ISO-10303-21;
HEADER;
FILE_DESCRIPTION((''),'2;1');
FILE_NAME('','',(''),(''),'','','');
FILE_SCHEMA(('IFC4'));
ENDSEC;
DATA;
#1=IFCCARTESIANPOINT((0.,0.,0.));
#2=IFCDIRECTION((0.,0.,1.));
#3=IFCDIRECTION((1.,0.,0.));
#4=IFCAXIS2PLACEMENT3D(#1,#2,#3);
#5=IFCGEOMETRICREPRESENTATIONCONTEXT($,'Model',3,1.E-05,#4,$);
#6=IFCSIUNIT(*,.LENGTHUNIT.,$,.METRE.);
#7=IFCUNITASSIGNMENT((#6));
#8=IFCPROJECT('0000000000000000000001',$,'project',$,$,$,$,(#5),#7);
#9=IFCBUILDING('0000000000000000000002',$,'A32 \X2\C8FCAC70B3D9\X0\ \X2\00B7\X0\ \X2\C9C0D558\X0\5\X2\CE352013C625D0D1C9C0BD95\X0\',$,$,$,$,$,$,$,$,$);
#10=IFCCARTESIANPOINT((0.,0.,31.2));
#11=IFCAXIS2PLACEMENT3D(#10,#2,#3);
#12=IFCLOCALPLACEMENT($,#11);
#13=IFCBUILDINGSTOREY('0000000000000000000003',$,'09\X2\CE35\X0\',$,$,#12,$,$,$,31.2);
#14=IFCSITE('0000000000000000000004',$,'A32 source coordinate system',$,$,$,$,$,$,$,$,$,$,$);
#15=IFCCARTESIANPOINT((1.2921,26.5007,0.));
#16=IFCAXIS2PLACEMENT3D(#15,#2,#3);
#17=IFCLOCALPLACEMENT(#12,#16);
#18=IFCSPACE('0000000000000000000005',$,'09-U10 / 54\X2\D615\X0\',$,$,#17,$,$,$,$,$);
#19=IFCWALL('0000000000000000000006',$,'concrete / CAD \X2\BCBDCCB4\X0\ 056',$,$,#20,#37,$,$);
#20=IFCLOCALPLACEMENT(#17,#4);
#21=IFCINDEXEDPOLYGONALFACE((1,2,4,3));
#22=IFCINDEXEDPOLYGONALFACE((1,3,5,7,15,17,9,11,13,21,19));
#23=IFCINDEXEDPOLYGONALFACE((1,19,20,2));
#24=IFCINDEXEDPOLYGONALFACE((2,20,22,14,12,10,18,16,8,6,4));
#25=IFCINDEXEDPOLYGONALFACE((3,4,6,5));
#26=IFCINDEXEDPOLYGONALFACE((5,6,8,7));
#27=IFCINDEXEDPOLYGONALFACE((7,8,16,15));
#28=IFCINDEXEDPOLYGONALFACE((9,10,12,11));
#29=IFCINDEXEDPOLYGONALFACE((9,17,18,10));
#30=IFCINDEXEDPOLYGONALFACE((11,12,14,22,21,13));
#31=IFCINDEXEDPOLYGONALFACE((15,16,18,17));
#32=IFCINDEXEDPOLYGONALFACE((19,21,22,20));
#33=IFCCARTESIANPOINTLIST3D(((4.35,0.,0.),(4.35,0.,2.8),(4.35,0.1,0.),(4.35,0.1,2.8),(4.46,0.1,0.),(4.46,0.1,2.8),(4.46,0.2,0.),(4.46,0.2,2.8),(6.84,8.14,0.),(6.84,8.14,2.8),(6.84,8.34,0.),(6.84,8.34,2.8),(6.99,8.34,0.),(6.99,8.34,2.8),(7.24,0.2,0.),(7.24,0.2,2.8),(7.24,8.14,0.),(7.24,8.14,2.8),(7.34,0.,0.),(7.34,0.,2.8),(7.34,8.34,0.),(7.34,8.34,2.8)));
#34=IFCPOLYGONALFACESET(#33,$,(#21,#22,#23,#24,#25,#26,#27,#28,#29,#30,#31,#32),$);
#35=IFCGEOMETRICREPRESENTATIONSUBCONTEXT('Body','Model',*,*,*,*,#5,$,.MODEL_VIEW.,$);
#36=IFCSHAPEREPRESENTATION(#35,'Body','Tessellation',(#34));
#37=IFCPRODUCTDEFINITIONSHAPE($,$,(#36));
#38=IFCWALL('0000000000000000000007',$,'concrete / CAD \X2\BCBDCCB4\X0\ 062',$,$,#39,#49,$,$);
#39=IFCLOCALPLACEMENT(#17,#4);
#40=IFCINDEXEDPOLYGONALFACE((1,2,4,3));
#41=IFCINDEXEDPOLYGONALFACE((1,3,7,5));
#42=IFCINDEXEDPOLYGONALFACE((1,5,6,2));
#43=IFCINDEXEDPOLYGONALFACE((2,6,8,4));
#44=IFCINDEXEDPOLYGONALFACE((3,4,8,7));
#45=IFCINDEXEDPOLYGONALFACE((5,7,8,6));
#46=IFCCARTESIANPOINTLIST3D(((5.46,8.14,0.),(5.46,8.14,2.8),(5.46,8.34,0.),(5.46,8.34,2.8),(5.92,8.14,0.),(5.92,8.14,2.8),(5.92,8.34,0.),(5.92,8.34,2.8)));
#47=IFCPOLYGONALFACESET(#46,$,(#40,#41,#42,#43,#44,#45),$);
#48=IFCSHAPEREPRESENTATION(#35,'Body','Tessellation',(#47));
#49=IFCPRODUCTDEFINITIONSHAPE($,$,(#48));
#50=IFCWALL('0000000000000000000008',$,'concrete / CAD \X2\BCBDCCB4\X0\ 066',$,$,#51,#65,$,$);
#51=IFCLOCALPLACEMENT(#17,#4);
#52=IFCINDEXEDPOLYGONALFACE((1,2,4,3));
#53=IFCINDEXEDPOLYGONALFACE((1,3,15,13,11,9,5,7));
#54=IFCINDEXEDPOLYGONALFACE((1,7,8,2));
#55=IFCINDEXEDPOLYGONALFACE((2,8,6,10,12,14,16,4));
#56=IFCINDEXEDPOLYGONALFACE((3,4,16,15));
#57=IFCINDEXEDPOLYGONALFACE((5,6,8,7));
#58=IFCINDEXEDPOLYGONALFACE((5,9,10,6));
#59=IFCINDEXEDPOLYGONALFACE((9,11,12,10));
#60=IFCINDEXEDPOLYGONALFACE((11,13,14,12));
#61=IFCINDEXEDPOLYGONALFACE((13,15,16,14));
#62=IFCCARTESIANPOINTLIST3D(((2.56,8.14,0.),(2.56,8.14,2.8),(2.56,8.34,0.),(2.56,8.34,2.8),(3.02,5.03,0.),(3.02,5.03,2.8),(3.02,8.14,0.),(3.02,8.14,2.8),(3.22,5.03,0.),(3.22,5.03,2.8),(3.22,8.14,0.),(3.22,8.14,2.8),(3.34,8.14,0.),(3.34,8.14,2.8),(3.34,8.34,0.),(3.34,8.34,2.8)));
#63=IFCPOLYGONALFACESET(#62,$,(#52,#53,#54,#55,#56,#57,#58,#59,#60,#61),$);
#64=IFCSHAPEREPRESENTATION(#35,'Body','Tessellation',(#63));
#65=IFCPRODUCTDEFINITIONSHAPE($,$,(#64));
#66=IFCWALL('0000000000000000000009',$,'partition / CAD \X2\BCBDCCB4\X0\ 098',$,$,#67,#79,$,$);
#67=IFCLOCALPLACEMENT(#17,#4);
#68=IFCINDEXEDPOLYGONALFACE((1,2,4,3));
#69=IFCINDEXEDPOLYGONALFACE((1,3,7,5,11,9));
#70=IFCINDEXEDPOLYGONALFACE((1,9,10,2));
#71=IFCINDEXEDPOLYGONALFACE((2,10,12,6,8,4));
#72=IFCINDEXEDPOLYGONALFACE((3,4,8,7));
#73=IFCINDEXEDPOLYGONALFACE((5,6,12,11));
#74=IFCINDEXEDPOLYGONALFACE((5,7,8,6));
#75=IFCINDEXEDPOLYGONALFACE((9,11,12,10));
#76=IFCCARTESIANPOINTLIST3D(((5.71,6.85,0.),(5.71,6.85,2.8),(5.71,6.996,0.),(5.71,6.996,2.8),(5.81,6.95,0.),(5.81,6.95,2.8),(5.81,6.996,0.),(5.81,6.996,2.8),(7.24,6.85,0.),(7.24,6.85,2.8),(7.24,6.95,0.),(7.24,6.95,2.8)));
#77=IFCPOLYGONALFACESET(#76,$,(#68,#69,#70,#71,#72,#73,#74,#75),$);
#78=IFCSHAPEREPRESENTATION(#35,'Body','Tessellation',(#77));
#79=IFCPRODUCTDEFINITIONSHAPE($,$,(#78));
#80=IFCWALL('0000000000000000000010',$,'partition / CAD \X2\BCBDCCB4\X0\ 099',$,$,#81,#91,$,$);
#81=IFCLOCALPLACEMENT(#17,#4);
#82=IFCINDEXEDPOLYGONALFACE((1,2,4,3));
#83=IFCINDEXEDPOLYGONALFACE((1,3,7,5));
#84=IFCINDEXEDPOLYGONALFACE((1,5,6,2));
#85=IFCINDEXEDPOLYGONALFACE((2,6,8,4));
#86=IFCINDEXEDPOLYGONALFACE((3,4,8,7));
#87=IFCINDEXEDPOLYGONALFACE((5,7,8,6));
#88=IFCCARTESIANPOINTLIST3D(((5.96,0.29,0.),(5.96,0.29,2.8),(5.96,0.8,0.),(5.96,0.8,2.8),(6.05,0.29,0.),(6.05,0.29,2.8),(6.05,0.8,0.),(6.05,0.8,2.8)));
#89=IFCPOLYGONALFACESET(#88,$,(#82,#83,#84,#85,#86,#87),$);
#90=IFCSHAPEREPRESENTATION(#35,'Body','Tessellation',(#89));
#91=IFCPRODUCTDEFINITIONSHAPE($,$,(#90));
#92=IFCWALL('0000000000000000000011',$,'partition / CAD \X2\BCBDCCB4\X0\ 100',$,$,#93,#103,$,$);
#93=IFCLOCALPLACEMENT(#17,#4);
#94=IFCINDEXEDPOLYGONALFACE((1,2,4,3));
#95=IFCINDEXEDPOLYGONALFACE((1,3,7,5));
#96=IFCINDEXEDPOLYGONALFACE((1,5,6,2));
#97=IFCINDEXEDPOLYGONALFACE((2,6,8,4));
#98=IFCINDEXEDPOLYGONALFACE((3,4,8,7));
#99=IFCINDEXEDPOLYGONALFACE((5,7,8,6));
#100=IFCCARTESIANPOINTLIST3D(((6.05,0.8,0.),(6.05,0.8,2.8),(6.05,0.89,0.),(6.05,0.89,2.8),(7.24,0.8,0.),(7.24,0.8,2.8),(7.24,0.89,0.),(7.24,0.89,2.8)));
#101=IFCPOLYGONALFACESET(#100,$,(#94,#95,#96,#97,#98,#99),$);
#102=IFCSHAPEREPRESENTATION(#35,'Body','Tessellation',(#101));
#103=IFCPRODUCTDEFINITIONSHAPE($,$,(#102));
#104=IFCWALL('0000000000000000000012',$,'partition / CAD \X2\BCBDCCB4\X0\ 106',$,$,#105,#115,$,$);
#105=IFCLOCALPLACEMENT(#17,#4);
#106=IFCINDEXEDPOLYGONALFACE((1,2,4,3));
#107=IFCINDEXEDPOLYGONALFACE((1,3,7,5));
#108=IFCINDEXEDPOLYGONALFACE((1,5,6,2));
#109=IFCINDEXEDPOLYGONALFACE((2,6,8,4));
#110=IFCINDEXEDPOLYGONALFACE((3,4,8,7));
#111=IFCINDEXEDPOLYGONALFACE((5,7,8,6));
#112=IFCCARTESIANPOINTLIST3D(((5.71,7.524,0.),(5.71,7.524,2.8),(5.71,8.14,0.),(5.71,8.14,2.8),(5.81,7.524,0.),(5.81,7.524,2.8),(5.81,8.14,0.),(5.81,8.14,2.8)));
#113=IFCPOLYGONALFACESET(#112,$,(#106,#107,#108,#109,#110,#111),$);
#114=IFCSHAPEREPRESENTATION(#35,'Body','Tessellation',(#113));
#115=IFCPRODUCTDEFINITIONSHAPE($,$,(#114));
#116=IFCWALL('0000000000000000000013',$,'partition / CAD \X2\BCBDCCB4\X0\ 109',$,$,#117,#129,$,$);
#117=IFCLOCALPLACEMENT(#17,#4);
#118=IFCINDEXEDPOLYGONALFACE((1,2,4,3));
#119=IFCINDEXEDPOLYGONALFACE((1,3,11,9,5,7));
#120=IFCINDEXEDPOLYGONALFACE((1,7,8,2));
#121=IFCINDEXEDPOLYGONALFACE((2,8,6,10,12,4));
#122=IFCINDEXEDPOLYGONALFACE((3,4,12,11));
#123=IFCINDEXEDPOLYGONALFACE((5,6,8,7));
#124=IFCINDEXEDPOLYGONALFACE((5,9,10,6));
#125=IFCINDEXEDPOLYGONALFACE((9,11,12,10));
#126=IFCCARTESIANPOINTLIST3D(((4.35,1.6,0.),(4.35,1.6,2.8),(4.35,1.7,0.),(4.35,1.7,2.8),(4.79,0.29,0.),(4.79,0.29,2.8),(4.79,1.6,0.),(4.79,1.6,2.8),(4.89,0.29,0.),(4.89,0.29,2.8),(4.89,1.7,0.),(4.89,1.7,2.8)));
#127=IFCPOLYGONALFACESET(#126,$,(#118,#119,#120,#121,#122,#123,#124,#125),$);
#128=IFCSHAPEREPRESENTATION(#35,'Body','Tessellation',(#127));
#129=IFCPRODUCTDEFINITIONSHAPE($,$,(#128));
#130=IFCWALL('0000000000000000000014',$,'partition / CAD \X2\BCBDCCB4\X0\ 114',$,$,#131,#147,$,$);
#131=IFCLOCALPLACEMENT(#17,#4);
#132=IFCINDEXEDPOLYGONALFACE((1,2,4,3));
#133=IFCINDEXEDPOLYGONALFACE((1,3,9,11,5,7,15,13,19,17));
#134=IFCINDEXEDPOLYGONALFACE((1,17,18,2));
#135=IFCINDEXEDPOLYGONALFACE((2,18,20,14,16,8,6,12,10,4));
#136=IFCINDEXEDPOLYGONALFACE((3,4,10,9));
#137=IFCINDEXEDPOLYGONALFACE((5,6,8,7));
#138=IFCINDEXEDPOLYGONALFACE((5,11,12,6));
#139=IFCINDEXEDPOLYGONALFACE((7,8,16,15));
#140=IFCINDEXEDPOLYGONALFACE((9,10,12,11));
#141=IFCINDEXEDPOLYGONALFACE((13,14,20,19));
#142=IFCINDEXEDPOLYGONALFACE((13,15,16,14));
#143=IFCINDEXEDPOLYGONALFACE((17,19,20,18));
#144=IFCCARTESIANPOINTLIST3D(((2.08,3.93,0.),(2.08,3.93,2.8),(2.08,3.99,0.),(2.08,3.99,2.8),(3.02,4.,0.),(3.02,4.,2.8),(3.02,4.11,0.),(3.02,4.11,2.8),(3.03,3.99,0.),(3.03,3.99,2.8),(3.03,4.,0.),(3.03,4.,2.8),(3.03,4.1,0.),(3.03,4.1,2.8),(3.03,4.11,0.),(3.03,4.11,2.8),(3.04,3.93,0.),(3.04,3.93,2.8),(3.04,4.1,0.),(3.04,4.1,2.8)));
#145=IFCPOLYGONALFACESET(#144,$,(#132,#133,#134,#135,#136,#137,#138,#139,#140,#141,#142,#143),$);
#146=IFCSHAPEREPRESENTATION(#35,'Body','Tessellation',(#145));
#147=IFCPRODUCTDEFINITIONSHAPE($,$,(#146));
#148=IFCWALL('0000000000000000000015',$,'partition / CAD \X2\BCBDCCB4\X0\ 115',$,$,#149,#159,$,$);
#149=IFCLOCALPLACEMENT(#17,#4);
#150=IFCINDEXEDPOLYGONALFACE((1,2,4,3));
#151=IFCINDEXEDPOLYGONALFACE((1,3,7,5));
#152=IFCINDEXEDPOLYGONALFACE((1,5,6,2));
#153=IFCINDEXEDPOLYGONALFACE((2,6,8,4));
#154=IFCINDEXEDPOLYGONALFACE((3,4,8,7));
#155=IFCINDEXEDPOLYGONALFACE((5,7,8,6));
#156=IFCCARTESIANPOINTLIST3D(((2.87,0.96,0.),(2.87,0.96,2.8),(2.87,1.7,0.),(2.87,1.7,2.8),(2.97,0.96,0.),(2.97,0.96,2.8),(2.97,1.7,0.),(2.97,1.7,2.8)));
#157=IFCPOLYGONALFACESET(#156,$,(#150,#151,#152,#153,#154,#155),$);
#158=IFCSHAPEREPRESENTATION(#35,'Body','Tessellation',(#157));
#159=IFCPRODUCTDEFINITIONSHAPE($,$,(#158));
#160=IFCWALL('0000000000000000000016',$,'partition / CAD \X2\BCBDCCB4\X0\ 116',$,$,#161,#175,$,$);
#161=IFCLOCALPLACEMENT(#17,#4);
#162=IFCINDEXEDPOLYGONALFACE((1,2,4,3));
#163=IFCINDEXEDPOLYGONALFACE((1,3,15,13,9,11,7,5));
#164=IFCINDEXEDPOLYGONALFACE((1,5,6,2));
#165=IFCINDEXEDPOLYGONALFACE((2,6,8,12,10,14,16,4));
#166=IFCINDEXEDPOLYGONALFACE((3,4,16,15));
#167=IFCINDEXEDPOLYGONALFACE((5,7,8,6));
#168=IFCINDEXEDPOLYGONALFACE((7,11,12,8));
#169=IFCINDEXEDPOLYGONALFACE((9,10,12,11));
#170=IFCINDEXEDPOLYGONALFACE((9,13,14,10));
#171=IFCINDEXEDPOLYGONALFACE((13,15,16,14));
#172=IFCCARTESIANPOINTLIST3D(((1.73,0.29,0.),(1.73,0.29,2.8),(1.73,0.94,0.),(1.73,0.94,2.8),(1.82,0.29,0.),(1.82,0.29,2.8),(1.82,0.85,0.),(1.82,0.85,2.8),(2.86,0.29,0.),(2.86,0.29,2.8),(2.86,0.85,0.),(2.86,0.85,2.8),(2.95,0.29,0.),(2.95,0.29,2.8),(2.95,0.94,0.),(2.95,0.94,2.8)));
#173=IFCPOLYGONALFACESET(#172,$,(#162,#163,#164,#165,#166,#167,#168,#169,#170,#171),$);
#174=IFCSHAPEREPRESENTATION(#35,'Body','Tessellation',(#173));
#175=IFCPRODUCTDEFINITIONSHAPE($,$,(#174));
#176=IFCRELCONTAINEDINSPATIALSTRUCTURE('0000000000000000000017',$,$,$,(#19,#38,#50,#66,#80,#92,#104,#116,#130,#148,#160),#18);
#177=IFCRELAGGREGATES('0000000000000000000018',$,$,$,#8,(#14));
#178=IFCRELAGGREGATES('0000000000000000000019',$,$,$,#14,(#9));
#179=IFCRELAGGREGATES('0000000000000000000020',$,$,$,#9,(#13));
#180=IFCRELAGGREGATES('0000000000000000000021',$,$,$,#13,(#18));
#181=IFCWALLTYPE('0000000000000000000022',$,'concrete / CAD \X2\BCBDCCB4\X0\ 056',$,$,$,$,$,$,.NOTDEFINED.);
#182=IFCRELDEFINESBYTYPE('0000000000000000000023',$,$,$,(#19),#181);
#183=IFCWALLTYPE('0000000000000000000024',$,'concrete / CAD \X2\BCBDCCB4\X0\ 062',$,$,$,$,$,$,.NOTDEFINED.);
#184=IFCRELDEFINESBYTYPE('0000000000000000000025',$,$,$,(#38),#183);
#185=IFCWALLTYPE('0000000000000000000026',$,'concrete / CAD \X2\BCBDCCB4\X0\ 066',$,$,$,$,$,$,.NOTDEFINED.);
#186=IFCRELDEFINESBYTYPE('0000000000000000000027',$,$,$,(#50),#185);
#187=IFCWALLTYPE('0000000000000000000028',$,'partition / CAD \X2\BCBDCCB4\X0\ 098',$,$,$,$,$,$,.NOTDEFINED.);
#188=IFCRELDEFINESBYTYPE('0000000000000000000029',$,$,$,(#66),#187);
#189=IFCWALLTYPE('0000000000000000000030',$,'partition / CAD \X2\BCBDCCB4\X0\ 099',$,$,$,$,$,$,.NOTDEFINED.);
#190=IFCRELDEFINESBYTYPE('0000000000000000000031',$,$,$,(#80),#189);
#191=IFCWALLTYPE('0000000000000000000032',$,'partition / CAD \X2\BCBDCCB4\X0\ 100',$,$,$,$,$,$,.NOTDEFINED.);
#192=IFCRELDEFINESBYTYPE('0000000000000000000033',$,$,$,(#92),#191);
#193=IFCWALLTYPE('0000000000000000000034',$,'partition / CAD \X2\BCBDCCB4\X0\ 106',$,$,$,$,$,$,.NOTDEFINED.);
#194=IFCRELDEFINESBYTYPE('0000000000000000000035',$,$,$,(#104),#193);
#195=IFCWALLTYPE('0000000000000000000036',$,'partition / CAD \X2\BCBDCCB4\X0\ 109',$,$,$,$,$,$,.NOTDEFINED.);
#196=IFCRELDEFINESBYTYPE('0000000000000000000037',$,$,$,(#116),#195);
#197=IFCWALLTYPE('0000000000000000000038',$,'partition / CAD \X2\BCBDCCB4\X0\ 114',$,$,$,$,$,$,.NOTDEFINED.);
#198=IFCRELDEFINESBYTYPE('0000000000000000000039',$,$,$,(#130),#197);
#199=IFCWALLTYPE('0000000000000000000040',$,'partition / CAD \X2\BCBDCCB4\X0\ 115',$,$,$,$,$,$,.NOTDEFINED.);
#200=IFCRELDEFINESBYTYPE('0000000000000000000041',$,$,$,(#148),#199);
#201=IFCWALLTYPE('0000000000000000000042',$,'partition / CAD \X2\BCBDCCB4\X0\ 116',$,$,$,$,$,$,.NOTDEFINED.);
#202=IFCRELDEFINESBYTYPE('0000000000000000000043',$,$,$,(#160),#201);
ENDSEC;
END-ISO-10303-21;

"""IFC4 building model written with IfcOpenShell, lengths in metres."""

from ifc_helpers import new_model, si_unit, frame, origin, origin_with_axes, place, context, subcontext, project, spatial, polyline, outline, extrude, source, transform, mapped, type_object, type_shapes, element, save


model = new_model("IFC4")

# Units and contexts
model_context = context("Model", 3, precision=1e-05, world=origin_with_axes())
body_context = subcontext(model_context, "Body", "Model", "MODEL_VIEW")
ifc_project = project(units=[si_unit("LENGTHUNIT", "METRE")], contexts=[model_context])

# Site, building, storey, space
site = spatial("IfcSite", under=ifc_project, Name="A32 source coordinate system")
building = spatial("IfcBuilding", under=site, Name="A32 주거동 · 지하5층–옥탑지붕")
storey_placement = place(None, frame((0.0, 0.0, 31.2), z_axis=(0.0, 0.0, 1.0), x_axis=(1.0, 0.0, 0.0)))
storey = spatial("IfcBuildingStorey", under=building, at=storey_placement, Name="09층", Elevation=31.2)
space_placement = place(storey_placement, frame((1.2921, 26.5007, 0.0), z_axis=(0.0, 0.0, 1.0), x_axis=(1.0, 0.0, 0.0)))
space = spatial("IfcSpace", under=storey, at=space_placement, Name="09-U10 / 54형")

# Walls
wall_type_1 = type_object("IfcWallType", Name="concrete / CAD 벽체 056", PredefinedType="NOTDEFINED")
shared_shape_1 = source(origin(), body_context, "Body", "SweptSolid", [
    extrude(outline(polyline([(7.24, 0.2), (7.24, 8.14), (6.84, 8.14), (6.84, 8.34), (6.99, 8.34), (6.99, 8.34), (7.34, 8.34), (7.34, 0.0), (4.35, 0.0), (4.35, 0.1), (4.46, 0.1), (4.46, 0.2), (7.24, 0.2)])), origin(), (0.0, 0.0, 1.0), 2.8),
])
type_shapes(wall_type_1, [shared_shape_1])
wall_1_placement = place(space_placement, origin_with_axes())
element("IfcWall", 1, at=wall_1_placement, inside=space, type_object=wall_type_1, Name="concrete / CAD 벽체 056", context=body_context, shape_type="MappedRepresentation", body=[
    mapped(shared_shape_1, transform((0.0, 0.0, 0.0), scale=1.0)),
])
wall_type_2 = type_object("IfcWallType", Name="concrete / CAD 벽체 062", PredefinedType="NOTDEFINED")
shared_shape_2 = source(origin(), body_context, "Body", "SweptSolid", [
    extrude(outline(polyline([(5.46, 8.14), (5.46, 8.34), (5.92, 8.34), (5.92, 8.14), (5.46, 8.14)])), origin(), (0.0, 0.0, 1.0), 2.8),
])
type_shapes(wall_type_2, [shared_shape_2])
wall_2_placement = place(space_placement, origin_with_axes())
element("IfcWall", 2, at=wall_2_placement, inside=space, type_object=wall_type_2, Name="concrete / CAD 벽체 062", context=body_context, shape_type="MappedRepresentation", body=[
    mapped(shared_shape_2, transform((0.0, 0.0, 0.0), scale=1.0)),
])
wall_type_3 = type_object("IfcWallType", Name="concrete / CAD 벽체 066", PredefinedType="NOTDEFINED")
shared_shape_3 = source(origin(), body_context, "Body", "SweptSolid", [
    extrude(outline(polyline([(3.22, 8.14), (3.22, 5.03), (3.02, 5.03), (3.02, 8.14), (2.56, 8.14), (2.56, 8.34), (3.34, 8.34), (3.34, 8.14), (3.22, 8.14)])), origin(), (0.0, 0.0, 1.0), 2.8),
])
type_shapes(wall_type_3, [shared_shape_3])
wall_3_placement = place(space_placement, origin_with_axes())
element("IfcWall", 3, at=wall_3_placement, inside=space, type_object=wall_type_3, Name="concrete / CAD 벽체 066", context=body_context, shape_type="MappedRepresentation", body=[
    mapped(shared_shape_3, transform((0.0, 0.0, 0.0), scale=1.0)),
])
wall_type_4 = type_object("IfcWallType", Name="partition / CAD 벽체 098", PredefinedType="NOTDEFINED")
shared_shape_4 = source(origin(), body_context, "Body", "SweptSolid", [
    extrude(outline(polyline([(5.71, 6.996), (5.81, 6.996), (5.81, 6.95), (7.24, 6.95), (7.24, 6.85), (5.71, 6.85), (5.71, 6.996)])), origin(), (0.0, 0.0, 1.0), 2.8),
])
type_shapes(wall_type_4, [shared_shape_4])
wall_4_placement = place(space_placement, origin_with_axes())
element("IfcWall", 4, at=wall_4_placement, inside=space, type_object=wall_type_4, Name="partition / CAD 벽체 098", context=body_context, shape_type="MappedRepresentation", body=[
    mapped(shared_shape_4, transform((0.0, 0.0, 0.0), scale=1.0)),
])
wall_type_5 = type_object("IfcWallType", Name="partition / CAD 벽체 099", PredefinedType="NOTDEFINED")
shared_shape_5 = source(origin(), body_context, "Body", "SweptSolid", [
    extrude(outline(polyline([(6.05, 0.8), (6.05, 0.29), (5.96, 0.29), (5.96, 0.8), (6.05, 0.8)])), origin(), (0.0, 0.0, 1.0), 2.8),
])
type_shapes(wall_type_5, [shared_shape_5])
wall_5_placement = place(space_placement, origin_with_axes())
element("IfcWall", 5, at=wall_5_placement, inside=space, type_object=wall_type_5, Name="partition / CAD 벽체 099", context=body_context, shape_type="MappedRepresentation", body=[
    mapped(shared_shape_5, transform((0.0, 0.0, 0.0), scale=1.0)),
])
wall_type_6 = type_object("IfcWallType", Name="partition / CAD 벽체 100", PredefinedType="NOTDEFINED")
shared_shape_6 = source(origin(), body_context, "Body", "SweptSolid", [
    extrude(outline(polyline([(7.24, 0.8), (6.05, 0.8), (6.05, 0.89), (7.24, 0.89), (7.24, 0.8)])), origin(), (0.0, 0.0, 1.0), 2.8),
])
type_shapes(wall_type_6, [shared_shape_6])
wall_6_placement = place(space_placement, origin_with_axes())
element("IfcWall", 6, at=wall_6_placement, inside=space, type_object=wall_type_6, Name="partition / CAD 벽체 100", context=body_context, shape_type="MappedRepresentation", body=[
    mapped(shared_shape_6, transform((0.0, 0.0, 0.0), scale=1.0)),
])
wall_type_7 = type_object("IfcWallType", Name="partition / CAD 벽체 106", PredefinedType="NOTDEFINED")
shared_shape_7 = source(origin(), body_context, "Body", "SweptSolid", [
    extrude(outline(polyline([(5.71, 8.14), (5.81, 8.14), (5.81, 7.524), (5.71, 7.524), (5.71, 8.14)])), origin(), (0.0, 0.0, 1.0), 2.8),
])
type_shapes(wall_type_7, [shared_shape_7])
wall_7_placement = place(space_placement, origin_with_axes())
element("IfcWall", 7, at=wall_7_placement, inside=space, type_object=wall_type_7, Name="partition / CAD 벽체 106", context=body_context, shape_type="MappedRepresentation", body=[
    mapped(shared_shape_7, transform((0.0, 0.0, 0.0), scale=1.0)),
])
wall_type_8 = type_object("IfcWallType", Name="partition / CAD 벽체 109", PredefinedType="NOTDEFINED")
shared_shape_8 = source(origin(), body_context, "Body", "SweptSolid", [
    extrude(outline(polyline([(4.79, 1.6), (4.35, 1.6), (4.35, 1.7), (4.89, 1.7), (4.89, 0.29), (4.79, 0.29), (4.79, 1.6)])), origin(), (0.0, 0.0, 1.0), 2.8),
])
type_shapes(wall_type_8, [shared_shape_8])
wall_8_placement = place(space_placement, origin_with_axes())
element("IfcWall", 8, at=wall_8_placement, inside=space, type_object=wall_type_8, Name="partition / CAD 벽체 109", context=body_context, shape_type="MappedRepresentation", body=[
    mapped(shared_shape_8, transform((0.0, 0.0, 0.0), scale=1.0)),
])
wall_type_9 = type_object("IfcWallType", Name="partition / CAD 벽체 114", PredefinedType="NOTDEFINED")
shared_shape_9 = source(origin(), body_context, "Body", "SweptSolid", [
    extrude(outline(polyline([(2.08, 3.99), (3.03, 3.99), (3.03, 4.0), (3.02, 4.0), (3.02, 4.11), (3.03, 4.11), (3.03, 4.1), (3.04, 4.1), (3.04, 3.93), (2.08, 3.93), (2.08, 3.99)])), origin(), (0.0, 0.0, 1.0), 2.8),
])
type_shapes(wall_type_9, [shared_shape_9])
wall_9_placement = place(space_placement, origin_with_axes())
element("IfcWall", 9, at=wall_9_placement, inside=space, type_object=wall_type_9, Name="partition / CAD 벽체 114", context=body_context, shape_type="MappedRepresentation", body=[
    mapped(shared_shape_9, transform((0.0, 0.0, 0.0), scale=1.0)),
])
wall_type_10 = type_object("IfcWallType", Name="partition / CAD 벽체 115", PredefinedType="NOTDEFINED")
shared_shape_10 = source(origin(), body_context, "Body", "SweptSolid", [
    extrude(outline(polyline([(2.87, 1.7), (2.97, 1.7), (2.97, 0.96), (2.87, 0.96), (2.87, 1.7)])), origin(), (0.0, 0.0, 1.0), 2.8),
])
type_shapes(wall_type_10, [shared_shape_10])
wall_10_placement = place(space_placement, origin_with_axes())
element("IfcWall", 10, at=wall_10_placement, inside=space, type_object=wall_type_10, Name="partition / CAD 벽체 115", context=body_context, shape_type="MappedRepresentation", body=[
    mapped(shared_shape_10, transform((0.0, 0.0, 0.0), scale=1.0)),
])
wall_type_11 = type_object("IfcWallType", Name="partition / CAD 벽체 116", PredefinedType="NOTDEFINED")
shared_shape_11 = source(origin(), body_context, "Body", "SweptSolid", [
    extrude(outline(polyline([(2.95, 0.29), (2.86, 0.29), (2.86, 0.85), (1.82, 0.85), (1.82, 0.29), (1.73, 0.29), (1.73, 0.94), (2.95, 0.94), (2.95, 0.29)])), origin(), (0.0, 0.0, 1.0), 2.8),
])
type_shapes(wall_type_11, [shared_shape_11])
wall_11_placement = place(space_placement, origin_with_axes())
element("IfcWall", 11, at=wall_11_placement, inside=space, type_object=wall_type_11, Name="partition / CAD 벽체 116", context=body_context, shape_type="MappedRepresentation", body=[
    mapped(shared_shape_11, transform((0.0, 0.0, 0.0), scale=1.0)),
])

save(model, "model.ifc")
